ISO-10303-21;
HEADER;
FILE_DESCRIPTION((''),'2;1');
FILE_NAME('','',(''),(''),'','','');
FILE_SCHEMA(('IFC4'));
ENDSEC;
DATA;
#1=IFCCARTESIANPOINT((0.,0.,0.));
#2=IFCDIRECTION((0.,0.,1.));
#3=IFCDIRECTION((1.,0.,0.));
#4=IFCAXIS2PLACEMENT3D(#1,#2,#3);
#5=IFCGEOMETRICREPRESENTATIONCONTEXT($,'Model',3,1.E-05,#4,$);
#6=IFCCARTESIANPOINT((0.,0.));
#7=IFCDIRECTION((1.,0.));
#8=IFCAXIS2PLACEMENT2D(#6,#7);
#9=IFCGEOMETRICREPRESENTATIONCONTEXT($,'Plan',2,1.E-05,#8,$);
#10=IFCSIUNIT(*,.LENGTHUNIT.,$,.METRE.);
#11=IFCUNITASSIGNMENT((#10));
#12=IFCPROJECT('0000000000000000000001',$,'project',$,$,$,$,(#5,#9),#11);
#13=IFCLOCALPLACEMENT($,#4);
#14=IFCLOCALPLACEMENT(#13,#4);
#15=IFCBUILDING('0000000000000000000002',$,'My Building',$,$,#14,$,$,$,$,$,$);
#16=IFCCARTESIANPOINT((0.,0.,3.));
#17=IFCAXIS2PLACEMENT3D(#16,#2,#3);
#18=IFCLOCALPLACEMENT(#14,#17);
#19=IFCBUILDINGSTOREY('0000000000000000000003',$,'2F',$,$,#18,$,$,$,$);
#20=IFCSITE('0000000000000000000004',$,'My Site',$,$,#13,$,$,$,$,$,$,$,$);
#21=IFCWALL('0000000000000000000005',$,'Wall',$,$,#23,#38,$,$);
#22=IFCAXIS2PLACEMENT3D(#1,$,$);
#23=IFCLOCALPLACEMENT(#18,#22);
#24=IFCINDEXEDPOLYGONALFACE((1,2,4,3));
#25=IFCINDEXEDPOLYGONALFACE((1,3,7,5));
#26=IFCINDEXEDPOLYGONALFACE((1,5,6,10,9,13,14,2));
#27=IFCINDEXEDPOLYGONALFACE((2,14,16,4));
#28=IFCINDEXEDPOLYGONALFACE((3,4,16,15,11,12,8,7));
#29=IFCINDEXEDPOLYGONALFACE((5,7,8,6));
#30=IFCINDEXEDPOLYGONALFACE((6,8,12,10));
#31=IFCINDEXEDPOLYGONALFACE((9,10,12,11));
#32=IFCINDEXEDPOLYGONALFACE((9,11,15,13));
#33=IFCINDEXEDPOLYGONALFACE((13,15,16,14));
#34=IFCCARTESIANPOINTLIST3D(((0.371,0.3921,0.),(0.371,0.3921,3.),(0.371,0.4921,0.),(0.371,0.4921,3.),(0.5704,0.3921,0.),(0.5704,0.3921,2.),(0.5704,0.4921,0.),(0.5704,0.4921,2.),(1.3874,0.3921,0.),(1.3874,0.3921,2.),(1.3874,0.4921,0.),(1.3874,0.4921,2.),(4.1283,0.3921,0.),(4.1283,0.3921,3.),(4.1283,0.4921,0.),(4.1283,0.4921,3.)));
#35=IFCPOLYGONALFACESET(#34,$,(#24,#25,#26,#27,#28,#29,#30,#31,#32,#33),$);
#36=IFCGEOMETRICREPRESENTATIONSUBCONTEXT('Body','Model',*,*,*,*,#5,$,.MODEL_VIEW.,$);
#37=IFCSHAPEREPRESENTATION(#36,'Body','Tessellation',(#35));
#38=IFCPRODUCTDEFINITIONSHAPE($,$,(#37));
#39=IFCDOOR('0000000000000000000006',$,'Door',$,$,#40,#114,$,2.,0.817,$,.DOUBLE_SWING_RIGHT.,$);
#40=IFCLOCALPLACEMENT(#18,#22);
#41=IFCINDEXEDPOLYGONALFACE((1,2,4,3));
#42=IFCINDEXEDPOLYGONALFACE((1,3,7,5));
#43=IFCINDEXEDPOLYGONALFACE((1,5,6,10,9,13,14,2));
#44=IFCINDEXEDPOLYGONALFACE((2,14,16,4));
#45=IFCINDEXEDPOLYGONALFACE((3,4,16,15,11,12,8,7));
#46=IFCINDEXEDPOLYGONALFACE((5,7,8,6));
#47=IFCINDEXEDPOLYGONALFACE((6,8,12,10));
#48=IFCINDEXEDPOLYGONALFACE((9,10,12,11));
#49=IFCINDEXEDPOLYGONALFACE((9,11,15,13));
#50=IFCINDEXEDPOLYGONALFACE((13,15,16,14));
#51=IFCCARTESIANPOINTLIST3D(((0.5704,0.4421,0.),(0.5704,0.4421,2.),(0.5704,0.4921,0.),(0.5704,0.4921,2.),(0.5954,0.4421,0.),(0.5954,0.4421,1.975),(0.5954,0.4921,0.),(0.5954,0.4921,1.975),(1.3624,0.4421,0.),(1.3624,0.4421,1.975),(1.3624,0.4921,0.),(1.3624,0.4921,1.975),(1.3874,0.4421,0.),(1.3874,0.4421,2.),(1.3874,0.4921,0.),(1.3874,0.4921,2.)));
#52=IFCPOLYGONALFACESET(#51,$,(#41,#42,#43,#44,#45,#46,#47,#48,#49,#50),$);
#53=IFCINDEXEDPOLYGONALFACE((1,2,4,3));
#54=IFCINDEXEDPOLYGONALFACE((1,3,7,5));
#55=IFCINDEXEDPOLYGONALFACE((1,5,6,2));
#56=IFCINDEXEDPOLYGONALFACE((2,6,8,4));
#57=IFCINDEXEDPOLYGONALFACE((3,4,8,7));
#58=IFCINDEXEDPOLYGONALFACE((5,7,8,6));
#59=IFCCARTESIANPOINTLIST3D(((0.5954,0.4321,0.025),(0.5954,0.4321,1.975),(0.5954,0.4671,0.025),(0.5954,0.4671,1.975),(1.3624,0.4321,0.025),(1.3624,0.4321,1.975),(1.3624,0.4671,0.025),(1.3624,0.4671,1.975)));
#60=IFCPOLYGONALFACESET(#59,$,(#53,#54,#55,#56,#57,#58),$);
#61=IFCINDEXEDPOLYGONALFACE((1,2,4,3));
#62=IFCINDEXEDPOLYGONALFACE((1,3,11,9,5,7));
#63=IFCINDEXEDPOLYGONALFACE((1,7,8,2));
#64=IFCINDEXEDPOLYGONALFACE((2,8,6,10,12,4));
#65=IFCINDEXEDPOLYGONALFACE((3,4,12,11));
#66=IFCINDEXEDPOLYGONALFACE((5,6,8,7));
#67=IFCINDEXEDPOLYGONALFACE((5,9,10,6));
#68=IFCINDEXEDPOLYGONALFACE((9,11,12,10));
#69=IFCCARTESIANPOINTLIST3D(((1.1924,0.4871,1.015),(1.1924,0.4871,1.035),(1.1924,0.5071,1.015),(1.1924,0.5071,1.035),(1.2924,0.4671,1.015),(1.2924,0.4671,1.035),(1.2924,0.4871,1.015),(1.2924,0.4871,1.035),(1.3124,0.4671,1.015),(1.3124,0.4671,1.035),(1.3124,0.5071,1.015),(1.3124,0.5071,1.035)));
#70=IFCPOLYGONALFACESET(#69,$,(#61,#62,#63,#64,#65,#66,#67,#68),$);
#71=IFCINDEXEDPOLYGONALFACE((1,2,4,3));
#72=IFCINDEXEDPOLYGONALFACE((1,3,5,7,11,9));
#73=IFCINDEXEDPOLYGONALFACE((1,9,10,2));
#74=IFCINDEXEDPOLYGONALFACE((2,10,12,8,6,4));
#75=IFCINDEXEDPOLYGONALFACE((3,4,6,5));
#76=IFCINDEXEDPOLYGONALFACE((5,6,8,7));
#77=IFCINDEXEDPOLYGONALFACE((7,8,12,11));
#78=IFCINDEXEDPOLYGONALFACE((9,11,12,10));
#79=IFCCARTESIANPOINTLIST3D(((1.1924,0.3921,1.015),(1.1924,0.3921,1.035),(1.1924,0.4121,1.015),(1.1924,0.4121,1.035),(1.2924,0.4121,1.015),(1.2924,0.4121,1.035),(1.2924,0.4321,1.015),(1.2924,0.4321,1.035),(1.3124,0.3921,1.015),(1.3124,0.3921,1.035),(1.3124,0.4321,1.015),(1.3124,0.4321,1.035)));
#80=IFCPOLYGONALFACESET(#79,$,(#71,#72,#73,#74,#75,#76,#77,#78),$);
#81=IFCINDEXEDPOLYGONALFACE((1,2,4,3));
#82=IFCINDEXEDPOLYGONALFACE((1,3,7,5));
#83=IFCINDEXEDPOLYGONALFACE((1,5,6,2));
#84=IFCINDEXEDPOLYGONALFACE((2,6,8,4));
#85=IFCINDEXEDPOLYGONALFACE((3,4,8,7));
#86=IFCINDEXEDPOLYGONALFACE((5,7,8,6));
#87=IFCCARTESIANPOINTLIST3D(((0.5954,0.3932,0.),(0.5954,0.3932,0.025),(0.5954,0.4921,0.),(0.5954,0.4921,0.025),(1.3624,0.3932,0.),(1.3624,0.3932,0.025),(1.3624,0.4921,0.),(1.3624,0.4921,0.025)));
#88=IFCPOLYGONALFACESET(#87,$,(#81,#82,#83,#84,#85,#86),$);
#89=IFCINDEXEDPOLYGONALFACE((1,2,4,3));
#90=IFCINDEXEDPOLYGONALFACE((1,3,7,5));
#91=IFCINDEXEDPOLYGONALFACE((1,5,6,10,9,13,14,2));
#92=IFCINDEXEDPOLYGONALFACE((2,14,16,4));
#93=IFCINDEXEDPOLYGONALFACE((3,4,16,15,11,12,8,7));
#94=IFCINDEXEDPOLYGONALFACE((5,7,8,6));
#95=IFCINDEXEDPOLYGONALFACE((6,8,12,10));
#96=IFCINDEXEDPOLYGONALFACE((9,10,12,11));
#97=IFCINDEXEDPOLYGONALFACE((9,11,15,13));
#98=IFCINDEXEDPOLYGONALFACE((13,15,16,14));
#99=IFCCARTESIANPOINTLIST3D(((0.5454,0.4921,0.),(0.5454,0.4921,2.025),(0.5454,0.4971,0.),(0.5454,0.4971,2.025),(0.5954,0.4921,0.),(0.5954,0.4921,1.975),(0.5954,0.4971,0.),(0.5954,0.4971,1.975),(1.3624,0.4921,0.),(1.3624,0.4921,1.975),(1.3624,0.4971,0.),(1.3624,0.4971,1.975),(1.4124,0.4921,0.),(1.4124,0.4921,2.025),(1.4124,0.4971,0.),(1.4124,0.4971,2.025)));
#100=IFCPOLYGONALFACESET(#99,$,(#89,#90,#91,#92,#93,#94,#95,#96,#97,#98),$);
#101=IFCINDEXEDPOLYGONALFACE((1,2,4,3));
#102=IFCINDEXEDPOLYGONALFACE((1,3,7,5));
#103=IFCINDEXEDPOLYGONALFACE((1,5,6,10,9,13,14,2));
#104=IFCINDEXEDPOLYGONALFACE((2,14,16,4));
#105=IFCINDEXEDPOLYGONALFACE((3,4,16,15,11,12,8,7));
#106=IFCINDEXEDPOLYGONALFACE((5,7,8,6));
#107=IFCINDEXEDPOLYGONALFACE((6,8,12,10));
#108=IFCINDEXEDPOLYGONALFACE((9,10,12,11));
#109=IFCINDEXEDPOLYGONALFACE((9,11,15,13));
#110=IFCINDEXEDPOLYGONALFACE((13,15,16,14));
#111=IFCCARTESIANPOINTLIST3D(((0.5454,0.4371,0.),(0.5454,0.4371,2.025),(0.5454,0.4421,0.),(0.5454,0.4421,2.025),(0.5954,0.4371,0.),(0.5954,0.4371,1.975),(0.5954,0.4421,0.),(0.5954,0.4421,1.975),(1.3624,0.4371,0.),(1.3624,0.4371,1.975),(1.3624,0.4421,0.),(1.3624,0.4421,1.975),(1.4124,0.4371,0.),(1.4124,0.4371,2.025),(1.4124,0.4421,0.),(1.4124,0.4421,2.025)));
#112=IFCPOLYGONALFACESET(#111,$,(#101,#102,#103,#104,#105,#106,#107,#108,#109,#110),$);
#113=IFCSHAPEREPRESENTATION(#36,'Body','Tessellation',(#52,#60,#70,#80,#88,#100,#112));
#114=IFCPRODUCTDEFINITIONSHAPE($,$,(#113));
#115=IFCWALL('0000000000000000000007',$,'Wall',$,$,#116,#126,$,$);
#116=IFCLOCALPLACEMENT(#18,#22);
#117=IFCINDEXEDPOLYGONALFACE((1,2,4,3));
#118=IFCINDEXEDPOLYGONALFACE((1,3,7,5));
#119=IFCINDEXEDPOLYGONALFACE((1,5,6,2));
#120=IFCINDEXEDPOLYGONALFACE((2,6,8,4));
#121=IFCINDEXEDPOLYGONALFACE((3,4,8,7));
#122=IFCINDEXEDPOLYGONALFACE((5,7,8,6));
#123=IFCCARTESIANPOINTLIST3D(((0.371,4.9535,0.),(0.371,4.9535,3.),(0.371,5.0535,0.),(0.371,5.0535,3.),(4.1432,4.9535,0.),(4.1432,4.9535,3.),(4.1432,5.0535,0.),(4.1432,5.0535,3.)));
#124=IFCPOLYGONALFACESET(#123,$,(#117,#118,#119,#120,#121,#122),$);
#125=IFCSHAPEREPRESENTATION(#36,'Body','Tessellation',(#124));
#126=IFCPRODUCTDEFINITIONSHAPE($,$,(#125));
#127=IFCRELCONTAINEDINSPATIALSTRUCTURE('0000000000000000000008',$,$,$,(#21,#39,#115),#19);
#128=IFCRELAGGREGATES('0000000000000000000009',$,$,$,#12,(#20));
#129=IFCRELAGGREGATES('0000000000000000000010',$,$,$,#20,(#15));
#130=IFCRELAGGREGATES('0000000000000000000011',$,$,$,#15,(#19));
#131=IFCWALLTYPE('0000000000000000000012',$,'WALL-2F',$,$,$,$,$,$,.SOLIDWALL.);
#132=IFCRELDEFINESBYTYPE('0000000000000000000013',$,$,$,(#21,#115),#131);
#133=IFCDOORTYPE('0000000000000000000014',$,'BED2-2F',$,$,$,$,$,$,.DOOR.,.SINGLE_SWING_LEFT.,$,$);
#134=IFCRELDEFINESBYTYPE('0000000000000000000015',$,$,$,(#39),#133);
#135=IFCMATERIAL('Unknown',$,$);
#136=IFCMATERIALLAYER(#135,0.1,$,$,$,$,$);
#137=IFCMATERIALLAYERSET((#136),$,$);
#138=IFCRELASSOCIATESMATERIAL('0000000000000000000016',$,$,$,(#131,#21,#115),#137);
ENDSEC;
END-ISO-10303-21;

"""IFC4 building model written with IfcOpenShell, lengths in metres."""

from ifc_helpers import new_model, entity, si_unit, frame, origin_with_axes, origin_2d_with_axis, place, context, subcontext, project, spatial, line, indexed_curve, outline, extrude, shape, source, transform, mapped, material, layer, layer_set, layer_usage, type_object, type_shapes, element, fill, save


model = new_model("IFC4")

# Units and contexts
model_context = context("Model", 3, precision=1e-05, world=origin_with_axes())
plan_context = context("Plan", 2, precision=1e-05, world=origin_2d_with_axis())
body_context_1 = subcontext(model_context, "Body", "Model", "MODEL_VIEW")
body_context_2 = subcontext(plan_context, "Body", "Plan", "PLAN_VIEW")
ifc_project = project(units=[si_unit("LENGTHUNIT", "METRE")], contexts=[model_context, plan_context])

# Site, building, storey
site_placement = place(None, origin_with_axes())
site = spatial("IfcSite", under=ifc_project, at=site_placement, Name="My Site")
building_placement = place(site_placement, origin_with_axes())
building = spatial("IfcBuilding", under=site, at=building_placement, Name="My Building")
storey_placement = place(building_placement, frame((0.0, 0.0, 3.0), z_axis=(0.0, 0.0, 1.0), x_axis=(1.0, 0.0, 0.0)))
storey = spatial("IfcBuildingStorey", under=building, at=storey_placement, Name="2F")

# Shared definitions
ifc_material = material(Name="Unknown")

# Shared definitions
ifc_layer_1 = layer(ifc_material, 0.1)
ifc_layer_set_1 = layer_set([ifc_layer_1])
wall_type = type_object("IfcWallType", Name="WALL-2F", PredefinedType="SOLIDWALL", material=ifc_layer_set_1)

# Wall, opening, door
ifc_layer_usage_1 = layer_usage(ifc_layer_set_1, "AXIS2", "POSITIVE", 0.0)
wall_1_placement = place(storey_placement, frame((4.1283, 0.4921, 0.0), z_axis=(0.0, 0.0, 1.0), x_axis=(-1.0, 0.0, 0.0)))
wall_1 = element("IfcWall", 1, at=wall_1_placement, inside=storey, type_object=wall_type, material=ifc_layer_usage_1, Name="Wall", context=body_context_1, shape_type="SweptSolid", body=[
    extrude(outline(indexed_curve([(0.0, 0.0), (0.0, 0.1), (3.7573, 0.1), (3.7573, 0.0)], segments=[line(1, 2, 3, 4, 1)])), origin_with_axes(), (0.0, 0.0, 1.0), 3.0),
])
shared_shape_1 = source(origin_with_axes(), body_context_1, "Body", "SweptSolid", [
    extrude(outline(indexed_curve([(0.0, 0.0), (0.817, 0.0), (0.817, 2.0), (0.0, 2.0)], segments=[line(1, 2, 3, 4, 1)])), frame((0.0, -0.6, 0.0), z_axis=(0.0, -1.0, 0.0), x_axis=(1.0, 0.0, 0.0)), (0.0, 0.0, -1.0), 1.2),
])
opening_1_placement = place(wall_1_placement, frame((2.741, 0.0, 0.0), z_axis=(0.0, 0.0, 1.0), x_axis=(1.0, -0.000001, 0.0)))
opening_1 = element("IfcOpeningElement", 2, at=opening_1_placement, cuts=wall_1, PredefinedType="OPENING", context=body_context_1, shape_type="MappedRepresentation", body=[
    mapped(shared_shape_1, transform((0.0, 0.0, 0.0), x_axis=(1.0, 0.0, 0.0), y_axis=(0.0, 1.0, 0.0), z_axis=(0.0, 0.0, 1.0), scale=1.0)),
])
door_type_1 = type_object("IfcDoorType", Name="BED2-2F", OperationType="SINGLE_SWING_LEFT", PredefinedType="DOOR")
shared_shape_2 = source(origin_with_axes(), body_context_1, "Body", "SweptSolid", [
    extrude(outline(indexed_curve([(0.0, 0.0), (0.0, 2.0), (0.817, 2.0), (0.817, 0.0), (0.792, 0.0), (0.792, 1.975), (0.025, 1.975), (0.025, 0.0)], segments=[line(1, 2, 3, 4, 5, 6, 7, 8, 1)])), frame((0.0, 0.0, 0.0), z_axis=(0.0, -1.0, 0.0), x_axis=(1.0, 0.0, 0.0)), (0.0, 0.0, -1.0), 0.05),
    extrude(outline(indexed_curve([(0.0, 0.0), (0.767, 0.0), (0.767, 0.035), (0.0, 0.035)], segments=[line(1, 2, 3, 4, 1)])), frame((0.025, 0.025, 0.025), z_axis=(0.0, 0.0, 1.0), x_axis=(1.0, 0.0, 0.0)), (0.0, 0.0, 1.0), 1.95),
    extrude(outline(indexed_curve([(0.0, 0.0), (0.0, -0.04), (0.12, -0.04), (0.12, -0.02), (0.02, -0.02), (0.02, 0.0)], segments=[line(1, 2, 3, 4, 5, 6, 1)])), frame((0.075, 0.025, 1.015), z_axis=(0.0, 0.0, 1.0), x_axis=(1.0, 0.0, 0.0)), (0.0, 0.0, 1.0), 0.02),
    extrude(outline(indexed_curve([(0.0, 0.0), (0.0, 0.04), (0.12, 0.04), (0.12, 0.02), (0.02, 0.02), (0.02, 0.0)], segments=[line(1, 2, 3, 4, 5, 6, 1)])), frame((0.075, 0.06, 1.015), z_axis=(0.0, 0.0, 1.0), x_axis=(1.0, 0.0, 0.0)), (0.0, 0.0, 1.0), 0.02),
    extrude(outline(indexed_curve([(0.0, 0.0), (0.767, 0.0), (0.767, 0.0989), (0.0, 0.0989)], segments=[line(1, 2, 3, 4, 1)])), frame((0.025, 0.0, 0.0), z_axis=(0.0, 0.0, 1.0), x_axis=(1.0, 0.0, 0.0)), (0.0, 0.0, 1.0), 0.025),
    extrude(outline(indexed_curve([(0.0, 0.0), (0.0, 2.025), (0.867, 2.025), (0.867, 0.0), (0.817, 0.0), (0.817, 1.975), (0.05, 1.975), (0.05, 0.0)], segments=[line(1, 2, 3, 4, 5, 6, 7, 8, 1)])), frame((-0.025, -0.005, 0.0), z_axis=(0.0, -1.0, 0.0), x_axis=(1.0, 0.0, 0.0)), (0.0, 0.0, -1.0), 0.005),
    extrude(outline(indexed_curve([(0.0, 0.0), (0.0, 2.025), (0.867, 2.025), (0.867, 0.0), (0.817, 0.0), (0.817, 1.975), (0.05, 1.975), (0.05, 0.0)], segments=[line(1, 2, 3, 4, 5, 6, 7, 8, 1)])), frame((-0.025, 0.05, 0.0), z_axis=(0.0, -1.0, 0.0), x_axis=(1.0, 0.0, 0.0)), (0.0, 0.0, -1.0), 0.005),
])
shared_shape_3 = source(origin_with_axes(), body_context_2, "Body", "Curve2D", [
    entity("IfcIndexedPolyCurve", entity("IfcCartesianPointList2D", [[0.0, 0.0], [0.025, 0.0], [0.025, 0.05], [0.0, 0.05]]), [entity("IfcLineIndex", [1, 2, 3, 4, 1])]),
    entity("IfcIndexedPolyCurve", entity("IfcCartesianPointList2D", [[0.817, 0.0], [0.792, 0.0], [0.792, 0.05], [0.817, 0.05]]), [entity("IfcLineIndex", [1, 2, 3, 4, 1])]),
    entity("IfcIndexedPolyCurve", entity("IfcCartesianPointList2D", [[0.792, 0.05], [0.792, -0.717], [0.757, -0.717]])),
    entity("IfcTrimmedCurve", entity("IfcEllipse", entity("IfcAxis2Placement2D", entity("IfcCartesianPoint", [0.757, 0.05]), entity("IfcDirection", [1.0, 0.0])), 0.732, 0.767), [entity("IfcCartesianPoint", [0.757, 0.817])], [entity("IfcCartesianPoint", [0.757, -0.717])], True, "CARTESIAN"),
    entity("IfcIndexedPolyCurve", entity("IfcCartesianPointList2D", [[0.792, 0.05], [0.757, 0.05], [0.757, 0.817], [0.792, 0.817]]), [entity("IfcLineIndex", [1, 2, 3, 4, 1])]),
])
type_shapes(door_type_1, [shared_shape_2, shared_shape_3])
door_1_placement = place(opening_1_placement, frame((0.0, 0.0, 0.0), z_axis=(0.0, 0.0, 1.0), x_axis=(1.0, 0.0, 0.0)))
door_1 = element("IfcDoor", 3, at=door_1_placement, inside=storey, type_object=door_type_1, Name="Door", OperationType="DOUBLE_SWING_RIGHT", OverallHeight=2.0, OverallWidth=0.817, shapes=[
    shape(body_context_1, "Body", "MappedRepresentation", [mapped(shared_shape_2, transform((0.0, 0.0, 0.0), x_axis=(1.0, 0.0, 0.0), y_axis=(0.0, 1.0, 0.0), z_axis=(0.0, 0.0, 1.0), scale=1.0))]),
    shape(body_context_2, "Body", "MappedRepresentation", [mapped(shared_shape_3, transform((0.0, 0.0, 0.0), x_axis=(1.0, 0.0, 0.0), y_axis=(0.0, 1.0, 0.0), z_axis=(0.0, 0.0, 1.0), scale=1.0))]),
])
fill(opening_1, door_1)

# Wall
ifc_layer_usage_2 = layer_usage(ifc_layer_set_1, "AXIS2", "POSITIVE", 0.0)
wall_2_placement = place(storey_placement, frame((4.1432, 5.0535, 0.0), z_axis=(0.0, 0.0, 1.0), x_axis=(-1.0, 0.0, 0.0)))
element("IfcWall", 4, at=wall_2_placement, inside=storey, type_object=wall_type, material=ifc_layer_usage_2, Name="Wall", context=body_context_1, shape_type="SweptSolid", body=[
    extrude(outline(indexed_curve([(0.0, 0.0), (0.0, 0.1), (3.7722, 0.1), (3.7722, 0.0)], segments=[line(1, 2, 3, 4, 1)])), origin_with_axes(), (0.0, 0.0, 1.0), 3.0),
])

save(model, "model.ifc")
